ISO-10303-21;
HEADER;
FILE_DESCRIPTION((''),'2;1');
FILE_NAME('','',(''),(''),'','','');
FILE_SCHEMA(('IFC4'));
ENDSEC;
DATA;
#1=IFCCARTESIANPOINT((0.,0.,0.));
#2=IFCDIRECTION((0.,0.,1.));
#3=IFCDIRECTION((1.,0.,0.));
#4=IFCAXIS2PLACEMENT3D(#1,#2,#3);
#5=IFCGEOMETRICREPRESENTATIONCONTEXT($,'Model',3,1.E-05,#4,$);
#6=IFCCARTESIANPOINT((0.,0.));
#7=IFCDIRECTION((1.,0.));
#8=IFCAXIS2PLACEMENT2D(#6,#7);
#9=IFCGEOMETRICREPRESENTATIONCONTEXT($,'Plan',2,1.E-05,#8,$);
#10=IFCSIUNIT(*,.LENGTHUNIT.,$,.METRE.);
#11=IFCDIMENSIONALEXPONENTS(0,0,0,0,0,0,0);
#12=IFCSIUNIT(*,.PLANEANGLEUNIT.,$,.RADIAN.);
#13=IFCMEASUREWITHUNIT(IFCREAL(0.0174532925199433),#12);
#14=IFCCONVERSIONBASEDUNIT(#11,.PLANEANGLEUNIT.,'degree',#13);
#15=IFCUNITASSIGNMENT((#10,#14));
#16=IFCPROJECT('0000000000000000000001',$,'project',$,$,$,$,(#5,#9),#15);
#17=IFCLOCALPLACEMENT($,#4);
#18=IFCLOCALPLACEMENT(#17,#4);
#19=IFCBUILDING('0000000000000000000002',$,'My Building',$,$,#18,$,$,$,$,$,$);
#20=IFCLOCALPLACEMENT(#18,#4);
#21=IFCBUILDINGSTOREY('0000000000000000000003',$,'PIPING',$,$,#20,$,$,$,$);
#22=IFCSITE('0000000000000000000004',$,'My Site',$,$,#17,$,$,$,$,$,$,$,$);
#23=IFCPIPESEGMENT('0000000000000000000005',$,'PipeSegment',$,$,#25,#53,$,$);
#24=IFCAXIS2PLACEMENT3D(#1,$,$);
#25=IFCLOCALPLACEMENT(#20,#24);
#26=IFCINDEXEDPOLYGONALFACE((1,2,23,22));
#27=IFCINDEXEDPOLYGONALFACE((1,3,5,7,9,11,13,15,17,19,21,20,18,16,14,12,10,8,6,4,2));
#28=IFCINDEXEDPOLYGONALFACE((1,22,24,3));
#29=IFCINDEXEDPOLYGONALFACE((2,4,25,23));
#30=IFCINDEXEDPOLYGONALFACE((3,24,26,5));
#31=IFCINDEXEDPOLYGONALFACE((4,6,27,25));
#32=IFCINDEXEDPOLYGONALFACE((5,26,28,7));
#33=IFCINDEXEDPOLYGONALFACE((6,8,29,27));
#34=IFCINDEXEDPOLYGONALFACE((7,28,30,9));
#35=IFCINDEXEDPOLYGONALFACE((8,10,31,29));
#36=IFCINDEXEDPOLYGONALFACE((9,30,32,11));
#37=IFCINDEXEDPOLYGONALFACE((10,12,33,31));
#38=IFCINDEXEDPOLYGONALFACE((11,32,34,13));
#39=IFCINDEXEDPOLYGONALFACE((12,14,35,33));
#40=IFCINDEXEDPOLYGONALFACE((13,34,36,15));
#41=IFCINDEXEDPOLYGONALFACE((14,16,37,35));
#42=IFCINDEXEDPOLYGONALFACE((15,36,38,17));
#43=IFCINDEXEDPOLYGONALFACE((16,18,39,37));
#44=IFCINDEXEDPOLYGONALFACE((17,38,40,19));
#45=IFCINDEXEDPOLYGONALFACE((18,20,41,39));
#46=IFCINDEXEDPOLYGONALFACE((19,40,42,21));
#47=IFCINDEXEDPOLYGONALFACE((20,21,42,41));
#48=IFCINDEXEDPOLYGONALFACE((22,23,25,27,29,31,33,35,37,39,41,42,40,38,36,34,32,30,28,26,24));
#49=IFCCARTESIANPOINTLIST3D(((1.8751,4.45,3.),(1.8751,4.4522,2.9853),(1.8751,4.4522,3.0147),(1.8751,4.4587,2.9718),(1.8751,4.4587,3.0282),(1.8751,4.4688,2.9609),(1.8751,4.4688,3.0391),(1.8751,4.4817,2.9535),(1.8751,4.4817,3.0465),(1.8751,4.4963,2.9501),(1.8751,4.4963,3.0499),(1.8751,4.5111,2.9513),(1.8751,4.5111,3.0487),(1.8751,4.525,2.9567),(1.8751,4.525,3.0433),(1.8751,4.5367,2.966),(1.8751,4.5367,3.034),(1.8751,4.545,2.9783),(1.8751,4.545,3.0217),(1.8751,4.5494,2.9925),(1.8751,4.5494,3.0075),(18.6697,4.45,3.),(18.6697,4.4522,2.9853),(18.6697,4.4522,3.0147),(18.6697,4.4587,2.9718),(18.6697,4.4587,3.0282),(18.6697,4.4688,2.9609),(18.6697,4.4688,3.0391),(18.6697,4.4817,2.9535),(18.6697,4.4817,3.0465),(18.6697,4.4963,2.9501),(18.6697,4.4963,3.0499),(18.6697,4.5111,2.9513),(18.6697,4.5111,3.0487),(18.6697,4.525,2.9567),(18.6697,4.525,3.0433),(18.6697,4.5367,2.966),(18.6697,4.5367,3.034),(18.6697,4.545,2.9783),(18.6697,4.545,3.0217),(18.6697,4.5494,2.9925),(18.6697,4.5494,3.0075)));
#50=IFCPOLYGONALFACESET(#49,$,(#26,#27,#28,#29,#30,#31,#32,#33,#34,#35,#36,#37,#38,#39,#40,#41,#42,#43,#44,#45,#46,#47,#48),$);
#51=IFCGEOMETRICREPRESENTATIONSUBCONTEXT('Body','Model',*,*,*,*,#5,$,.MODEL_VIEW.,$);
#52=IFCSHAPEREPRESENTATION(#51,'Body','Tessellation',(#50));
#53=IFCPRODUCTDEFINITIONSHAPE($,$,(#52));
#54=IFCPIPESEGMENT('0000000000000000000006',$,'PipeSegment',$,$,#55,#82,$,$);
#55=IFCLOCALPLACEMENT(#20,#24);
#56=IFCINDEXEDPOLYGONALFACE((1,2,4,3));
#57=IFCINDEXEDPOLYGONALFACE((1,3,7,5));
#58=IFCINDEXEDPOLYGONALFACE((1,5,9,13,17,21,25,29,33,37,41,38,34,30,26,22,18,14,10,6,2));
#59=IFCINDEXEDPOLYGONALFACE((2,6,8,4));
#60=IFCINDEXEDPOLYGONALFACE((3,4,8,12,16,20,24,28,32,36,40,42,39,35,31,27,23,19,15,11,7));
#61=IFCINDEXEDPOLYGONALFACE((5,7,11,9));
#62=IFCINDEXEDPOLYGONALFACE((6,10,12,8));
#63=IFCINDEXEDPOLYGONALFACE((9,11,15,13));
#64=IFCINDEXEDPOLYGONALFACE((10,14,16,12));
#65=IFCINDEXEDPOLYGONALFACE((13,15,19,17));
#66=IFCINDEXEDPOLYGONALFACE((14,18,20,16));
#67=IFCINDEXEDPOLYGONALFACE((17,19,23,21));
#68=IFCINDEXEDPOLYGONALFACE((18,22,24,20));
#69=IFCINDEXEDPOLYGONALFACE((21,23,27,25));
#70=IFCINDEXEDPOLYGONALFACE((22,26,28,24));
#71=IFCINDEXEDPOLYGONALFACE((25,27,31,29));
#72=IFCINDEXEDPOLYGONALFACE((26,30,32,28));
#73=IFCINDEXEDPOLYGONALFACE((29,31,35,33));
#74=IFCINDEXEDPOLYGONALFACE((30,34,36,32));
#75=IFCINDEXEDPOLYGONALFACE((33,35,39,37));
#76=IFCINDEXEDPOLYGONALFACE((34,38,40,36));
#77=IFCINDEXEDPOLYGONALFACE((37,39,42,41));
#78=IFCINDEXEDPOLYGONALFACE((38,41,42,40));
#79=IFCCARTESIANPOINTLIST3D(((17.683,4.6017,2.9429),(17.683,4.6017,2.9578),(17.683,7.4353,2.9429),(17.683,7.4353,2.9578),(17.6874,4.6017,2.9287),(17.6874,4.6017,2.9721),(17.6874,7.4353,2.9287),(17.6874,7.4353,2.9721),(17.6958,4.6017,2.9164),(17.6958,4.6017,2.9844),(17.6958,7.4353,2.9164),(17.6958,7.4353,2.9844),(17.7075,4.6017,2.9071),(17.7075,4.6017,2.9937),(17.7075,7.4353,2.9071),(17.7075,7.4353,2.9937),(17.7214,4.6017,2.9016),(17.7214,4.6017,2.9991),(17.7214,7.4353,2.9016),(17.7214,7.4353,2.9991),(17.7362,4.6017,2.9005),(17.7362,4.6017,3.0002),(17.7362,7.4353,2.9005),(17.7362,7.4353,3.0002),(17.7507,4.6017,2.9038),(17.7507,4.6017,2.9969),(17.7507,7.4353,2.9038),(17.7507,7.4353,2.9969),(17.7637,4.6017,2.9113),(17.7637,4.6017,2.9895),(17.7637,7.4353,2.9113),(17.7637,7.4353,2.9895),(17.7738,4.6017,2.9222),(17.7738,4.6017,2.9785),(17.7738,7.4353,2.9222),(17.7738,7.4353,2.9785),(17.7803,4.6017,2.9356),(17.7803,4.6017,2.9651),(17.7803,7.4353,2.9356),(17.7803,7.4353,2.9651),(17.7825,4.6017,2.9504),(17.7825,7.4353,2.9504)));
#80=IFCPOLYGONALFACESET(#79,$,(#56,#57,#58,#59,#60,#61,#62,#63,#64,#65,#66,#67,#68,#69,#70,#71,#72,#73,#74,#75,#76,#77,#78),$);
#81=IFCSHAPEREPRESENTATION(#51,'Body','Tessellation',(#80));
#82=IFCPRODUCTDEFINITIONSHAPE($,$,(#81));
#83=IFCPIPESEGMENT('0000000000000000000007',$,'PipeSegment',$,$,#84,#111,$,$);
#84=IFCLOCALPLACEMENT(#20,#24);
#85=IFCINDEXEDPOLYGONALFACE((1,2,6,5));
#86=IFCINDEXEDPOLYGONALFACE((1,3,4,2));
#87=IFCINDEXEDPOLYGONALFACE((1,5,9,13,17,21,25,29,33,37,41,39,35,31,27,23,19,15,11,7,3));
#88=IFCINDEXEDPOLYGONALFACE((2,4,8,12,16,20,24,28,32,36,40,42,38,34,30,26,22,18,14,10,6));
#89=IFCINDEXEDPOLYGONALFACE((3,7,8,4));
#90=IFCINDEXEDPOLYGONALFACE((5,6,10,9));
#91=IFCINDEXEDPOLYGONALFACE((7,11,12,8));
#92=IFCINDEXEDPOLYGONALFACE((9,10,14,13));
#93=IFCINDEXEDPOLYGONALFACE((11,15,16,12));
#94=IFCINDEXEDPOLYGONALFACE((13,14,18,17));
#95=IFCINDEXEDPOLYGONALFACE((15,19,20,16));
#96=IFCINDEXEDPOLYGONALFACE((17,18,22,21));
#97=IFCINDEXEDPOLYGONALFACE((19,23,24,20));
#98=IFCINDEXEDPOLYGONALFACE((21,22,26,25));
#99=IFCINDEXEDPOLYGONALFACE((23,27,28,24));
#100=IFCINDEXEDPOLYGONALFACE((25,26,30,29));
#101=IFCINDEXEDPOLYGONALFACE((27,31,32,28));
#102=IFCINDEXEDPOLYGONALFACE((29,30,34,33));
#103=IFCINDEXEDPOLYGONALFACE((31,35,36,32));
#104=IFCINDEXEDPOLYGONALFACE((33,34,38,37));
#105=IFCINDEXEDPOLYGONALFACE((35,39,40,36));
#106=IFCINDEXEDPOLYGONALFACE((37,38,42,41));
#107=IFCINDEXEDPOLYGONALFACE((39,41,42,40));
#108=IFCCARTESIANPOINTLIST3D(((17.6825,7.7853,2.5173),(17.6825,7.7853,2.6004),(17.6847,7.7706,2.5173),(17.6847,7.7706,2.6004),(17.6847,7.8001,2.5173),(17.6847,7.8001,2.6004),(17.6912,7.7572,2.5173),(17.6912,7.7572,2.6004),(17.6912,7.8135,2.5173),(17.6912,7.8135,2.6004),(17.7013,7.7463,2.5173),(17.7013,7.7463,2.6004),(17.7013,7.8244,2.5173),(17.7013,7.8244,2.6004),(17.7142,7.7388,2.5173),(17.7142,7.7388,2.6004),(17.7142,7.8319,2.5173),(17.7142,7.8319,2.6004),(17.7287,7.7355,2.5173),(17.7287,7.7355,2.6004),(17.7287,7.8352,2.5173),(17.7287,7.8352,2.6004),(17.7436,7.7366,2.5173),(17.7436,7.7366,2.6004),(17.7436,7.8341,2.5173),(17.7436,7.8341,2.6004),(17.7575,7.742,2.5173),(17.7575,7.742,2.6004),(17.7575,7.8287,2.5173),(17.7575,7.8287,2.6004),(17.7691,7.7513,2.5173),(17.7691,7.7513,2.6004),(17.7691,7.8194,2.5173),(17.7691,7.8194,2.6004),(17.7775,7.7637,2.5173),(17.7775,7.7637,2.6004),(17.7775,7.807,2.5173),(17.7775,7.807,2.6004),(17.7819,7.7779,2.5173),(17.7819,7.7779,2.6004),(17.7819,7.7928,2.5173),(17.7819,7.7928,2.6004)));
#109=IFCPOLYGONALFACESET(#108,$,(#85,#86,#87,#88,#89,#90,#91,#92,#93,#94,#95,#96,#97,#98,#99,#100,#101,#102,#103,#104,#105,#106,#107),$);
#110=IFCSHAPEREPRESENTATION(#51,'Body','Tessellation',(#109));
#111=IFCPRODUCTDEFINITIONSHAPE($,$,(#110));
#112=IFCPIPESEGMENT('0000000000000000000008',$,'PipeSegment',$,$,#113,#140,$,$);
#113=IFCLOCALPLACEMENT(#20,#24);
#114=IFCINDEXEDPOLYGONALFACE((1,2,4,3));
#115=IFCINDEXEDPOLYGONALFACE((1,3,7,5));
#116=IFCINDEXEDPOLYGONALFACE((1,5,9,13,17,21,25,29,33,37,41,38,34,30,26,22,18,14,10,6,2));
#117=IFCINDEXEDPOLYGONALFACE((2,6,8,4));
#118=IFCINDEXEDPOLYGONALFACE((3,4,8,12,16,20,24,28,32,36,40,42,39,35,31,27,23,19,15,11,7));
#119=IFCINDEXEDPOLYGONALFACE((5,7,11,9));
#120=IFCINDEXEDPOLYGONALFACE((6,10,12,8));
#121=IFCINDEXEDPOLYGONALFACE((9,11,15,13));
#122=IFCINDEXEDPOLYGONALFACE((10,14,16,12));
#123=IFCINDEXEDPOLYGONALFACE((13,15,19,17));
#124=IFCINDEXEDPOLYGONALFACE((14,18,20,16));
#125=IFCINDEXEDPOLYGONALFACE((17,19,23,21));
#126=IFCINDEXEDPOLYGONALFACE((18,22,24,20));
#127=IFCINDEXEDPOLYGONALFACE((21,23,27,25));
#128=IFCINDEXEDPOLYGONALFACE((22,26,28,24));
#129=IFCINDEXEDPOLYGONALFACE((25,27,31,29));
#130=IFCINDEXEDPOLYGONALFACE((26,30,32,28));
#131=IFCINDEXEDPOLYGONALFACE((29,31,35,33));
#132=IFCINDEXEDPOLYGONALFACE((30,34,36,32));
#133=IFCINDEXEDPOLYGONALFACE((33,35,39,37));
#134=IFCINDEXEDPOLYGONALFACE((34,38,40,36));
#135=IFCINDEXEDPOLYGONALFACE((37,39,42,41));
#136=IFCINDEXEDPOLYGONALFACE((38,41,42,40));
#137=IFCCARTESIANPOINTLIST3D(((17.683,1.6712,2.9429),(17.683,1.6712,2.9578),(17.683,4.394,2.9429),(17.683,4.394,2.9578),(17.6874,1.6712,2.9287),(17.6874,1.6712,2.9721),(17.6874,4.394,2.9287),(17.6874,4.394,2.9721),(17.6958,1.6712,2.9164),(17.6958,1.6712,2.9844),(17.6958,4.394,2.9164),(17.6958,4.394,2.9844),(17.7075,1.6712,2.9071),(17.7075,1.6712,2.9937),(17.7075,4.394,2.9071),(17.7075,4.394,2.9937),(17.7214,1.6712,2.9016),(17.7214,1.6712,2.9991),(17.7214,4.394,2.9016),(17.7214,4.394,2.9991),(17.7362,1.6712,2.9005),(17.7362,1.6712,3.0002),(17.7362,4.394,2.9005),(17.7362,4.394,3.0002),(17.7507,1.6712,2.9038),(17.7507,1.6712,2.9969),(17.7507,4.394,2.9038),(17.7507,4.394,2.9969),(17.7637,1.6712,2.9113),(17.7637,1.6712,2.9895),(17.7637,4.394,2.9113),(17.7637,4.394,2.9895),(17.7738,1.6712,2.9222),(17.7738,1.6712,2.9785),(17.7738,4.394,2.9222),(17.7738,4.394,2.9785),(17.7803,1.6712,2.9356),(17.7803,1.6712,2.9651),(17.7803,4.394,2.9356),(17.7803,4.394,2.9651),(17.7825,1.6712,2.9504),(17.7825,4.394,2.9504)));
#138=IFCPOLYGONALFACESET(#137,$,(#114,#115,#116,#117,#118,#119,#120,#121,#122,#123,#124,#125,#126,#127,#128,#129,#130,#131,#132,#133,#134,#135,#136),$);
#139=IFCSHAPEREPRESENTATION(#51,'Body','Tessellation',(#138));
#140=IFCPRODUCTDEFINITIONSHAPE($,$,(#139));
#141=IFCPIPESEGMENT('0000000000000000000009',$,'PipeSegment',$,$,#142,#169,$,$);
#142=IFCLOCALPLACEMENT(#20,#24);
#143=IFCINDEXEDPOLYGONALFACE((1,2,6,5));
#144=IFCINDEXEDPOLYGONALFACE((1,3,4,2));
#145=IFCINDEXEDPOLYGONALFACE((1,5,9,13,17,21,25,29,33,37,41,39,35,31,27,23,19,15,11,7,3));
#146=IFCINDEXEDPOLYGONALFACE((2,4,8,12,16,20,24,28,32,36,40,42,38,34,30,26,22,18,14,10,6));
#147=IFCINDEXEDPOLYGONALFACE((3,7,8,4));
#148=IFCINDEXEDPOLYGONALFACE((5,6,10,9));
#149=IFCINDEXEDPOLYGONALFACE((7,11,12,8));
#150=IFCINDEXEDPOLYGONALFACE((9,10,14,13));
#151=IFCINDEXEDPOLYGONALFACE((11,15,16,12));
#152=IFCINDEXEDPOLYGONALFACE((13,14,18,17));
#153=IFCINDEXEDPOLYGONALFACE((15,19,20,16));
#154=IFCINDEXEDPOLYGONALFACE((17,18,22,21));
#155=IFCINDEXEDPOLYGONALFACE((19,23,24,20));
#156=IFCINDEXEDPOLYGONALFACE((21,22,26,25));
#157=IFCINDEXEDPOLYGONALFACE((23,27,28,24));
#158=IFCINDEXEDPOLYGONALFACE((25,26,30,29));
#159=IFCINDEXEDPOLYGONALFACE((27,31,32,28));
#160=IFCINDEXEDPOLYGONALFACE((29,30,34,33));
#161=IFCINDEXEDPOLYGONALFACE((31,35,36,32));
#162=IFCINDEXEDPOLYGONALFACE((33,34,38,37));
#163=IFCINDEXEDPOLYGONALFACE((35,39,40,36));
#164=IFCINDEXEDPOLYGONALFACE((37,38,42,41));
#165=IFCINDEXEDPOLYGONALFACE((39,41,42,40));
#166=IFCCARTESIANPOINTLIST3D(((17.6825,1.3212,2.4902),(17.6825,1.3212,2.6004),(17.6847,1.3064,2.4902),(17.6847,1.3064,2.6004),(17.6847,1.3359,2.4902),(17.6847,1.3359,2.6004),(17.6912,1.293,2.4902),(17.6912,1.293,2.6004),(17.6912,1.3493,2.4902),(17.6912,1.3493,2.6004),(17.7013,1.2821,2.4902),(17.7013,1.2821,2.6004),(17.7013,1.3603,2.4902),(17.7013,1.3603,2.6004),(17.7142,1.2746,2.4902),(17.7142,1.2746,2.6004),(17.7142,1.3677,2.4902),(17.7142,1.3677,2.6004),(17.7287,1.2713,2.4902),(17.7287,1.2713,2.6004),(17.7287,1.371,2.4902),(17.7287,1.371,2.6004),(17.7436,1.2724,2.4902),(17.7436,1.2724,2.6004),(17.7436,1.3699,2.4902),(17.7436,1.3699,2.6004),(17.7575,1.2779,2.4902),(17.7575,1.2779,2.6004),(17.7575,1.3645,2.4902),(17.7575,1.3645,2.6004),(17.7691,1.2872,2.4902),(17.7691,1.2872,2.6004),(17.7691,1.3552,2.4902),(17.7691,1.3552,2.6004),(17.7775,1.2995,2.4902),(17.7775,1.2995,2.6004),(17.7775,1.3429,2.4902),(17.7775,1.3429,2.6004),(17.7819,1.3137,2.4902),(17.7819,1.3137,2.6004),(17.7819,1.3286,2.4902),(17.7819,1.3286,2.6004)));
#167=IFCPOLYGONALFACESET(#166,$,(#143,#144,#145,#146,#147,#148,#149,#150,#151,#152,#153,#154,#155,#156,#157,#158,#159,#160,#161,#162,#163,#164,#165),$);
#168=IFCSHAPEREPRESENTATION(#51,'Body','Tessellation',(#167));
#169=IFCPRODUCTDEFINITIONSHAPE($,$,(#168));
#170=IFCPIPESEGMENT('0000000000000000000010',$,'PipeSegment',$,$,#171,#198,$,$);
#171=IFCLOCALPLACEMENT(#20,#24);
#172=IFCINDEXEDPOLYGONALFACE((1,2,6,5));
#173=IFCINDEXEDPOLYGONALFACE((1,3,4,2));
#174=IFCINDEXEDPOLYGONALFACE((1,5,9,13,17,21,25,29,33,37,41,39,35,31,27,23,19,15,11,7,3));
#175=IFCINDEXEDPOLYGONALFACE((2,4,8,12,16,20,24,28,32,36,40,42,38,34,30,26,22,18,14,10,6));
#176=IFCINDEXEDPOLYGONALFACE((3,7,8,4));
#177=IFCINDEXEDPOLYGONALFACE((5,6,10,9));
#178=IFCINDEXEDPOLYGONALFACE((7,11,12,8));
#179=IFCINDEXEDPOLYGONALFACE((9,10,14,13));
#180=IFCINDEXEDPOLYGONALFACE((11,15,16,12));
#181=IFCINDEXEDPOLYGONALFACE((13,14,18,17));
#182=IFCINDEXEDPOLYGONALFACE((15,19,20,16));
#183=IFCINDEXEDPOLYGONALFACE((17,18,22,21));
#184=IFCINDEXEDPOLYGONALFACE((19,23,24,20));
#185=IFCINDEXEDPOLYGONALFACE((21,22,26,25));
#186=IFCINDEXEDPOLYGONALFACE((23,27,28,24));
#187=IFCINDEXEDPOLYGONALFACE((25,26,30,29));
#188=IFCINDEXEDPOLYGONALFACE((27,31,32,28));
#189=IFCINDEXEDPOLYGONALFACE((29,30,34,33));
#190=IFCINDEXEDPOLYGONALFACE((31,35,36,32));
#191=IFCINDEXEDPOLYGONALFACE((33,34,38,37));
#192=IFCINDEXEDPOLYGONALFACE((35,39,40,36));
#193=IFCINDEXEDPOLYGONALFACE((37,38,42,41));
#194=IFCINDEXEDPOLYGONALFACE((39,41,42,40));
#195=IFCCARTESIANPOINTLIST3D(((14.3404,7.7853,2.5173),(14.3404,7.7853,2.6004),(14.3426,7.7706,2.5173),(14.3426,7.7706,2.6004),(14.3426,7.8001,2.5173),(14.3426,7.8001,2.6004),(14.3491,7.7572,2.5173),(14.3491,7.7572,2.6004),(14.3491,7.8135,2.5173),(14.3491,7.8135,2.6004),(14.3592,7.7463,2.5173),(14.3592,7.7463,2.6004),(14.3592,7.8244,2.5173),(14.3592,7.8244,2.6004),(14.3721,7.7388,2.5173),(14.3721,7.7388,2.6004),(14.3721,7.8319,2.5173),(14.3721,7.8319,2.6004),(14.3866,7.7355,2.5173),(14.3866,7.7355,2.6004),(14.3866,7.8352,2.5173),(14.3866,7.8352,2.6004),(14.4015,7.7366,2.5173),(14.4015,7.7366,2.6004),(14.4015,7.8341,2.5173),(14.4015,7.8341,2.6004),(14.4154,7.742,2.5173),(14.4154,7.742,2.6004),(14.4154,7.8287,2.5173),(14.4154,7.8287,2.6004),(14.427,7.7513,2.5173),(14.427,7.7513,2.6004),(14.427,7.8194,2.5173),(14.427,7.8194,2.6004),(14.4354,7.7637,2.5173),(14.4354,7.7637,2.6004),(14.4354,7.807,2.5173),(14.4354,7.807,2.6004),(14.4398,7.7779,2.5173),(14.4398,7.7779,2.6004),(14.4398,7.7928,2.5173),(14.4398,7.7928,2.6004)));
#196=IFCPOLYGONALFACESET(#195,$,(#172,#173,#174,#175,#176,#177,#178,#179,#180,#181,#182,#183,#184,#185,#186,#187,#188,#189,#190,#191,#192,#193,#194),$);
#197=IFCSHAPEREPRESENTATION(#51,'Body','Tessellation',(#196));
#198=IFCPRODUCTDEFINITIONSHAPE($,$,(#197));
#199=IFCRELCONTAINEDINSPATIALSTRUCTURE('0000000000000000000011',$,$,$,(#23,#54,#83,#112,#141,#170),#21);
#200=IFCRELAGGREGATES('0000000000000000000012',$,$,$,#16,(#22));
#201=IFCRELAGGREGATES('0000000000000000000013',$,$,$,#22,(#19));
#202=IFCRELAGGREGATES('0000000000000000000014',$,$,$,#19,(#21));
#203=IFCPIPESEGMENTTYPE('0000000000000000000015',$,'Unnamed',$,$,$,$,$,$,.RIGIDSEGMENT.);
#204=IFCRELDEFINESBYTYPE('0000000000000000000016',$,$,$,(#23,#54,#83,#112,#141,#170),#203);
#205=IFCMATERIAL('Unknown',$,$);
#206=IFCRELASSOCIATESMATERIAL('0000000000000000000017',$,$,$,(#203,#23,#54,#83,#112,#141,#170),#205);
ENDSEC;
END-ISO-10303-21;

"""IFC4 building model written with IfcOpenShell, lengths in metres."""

from ifc_helpers import new_model, entity, si_unit, converted_unit, frame, origin_with_axes, origin_2d_with_axis, place, context, subcontext, project, spatial, circle, extrude, material, material_profile, profile_set, profile_usage, type_object, element, save


model = new_model("IFC4")

# Units and contexts
model_context = context("Model", 3, precision=1e-05, world=origin_with_axes())
plan_context = context("Plan", 2, precision=1e-05, world=origin_2d_with_axis())
body_context = subcontext(model_context, "Body", "Model", "MODEL_VIEW")
ifc_project = project(units=[si_unit("LENGTHUNIT", "METRE"), converted_unit("PLANEANGLEUNIT", "degree", entity("IfcReal", 0.0174532925199433), si_unit("PLANEANGLEUNIT", "RADIAN"), dimensions=[0, 0, 0, 0, 0, 0, 0])], contexts=[model_context, plan_context])

# Site, building, storey
site_placement = place(None, origin_with_axes())
site = spatial("IfcSite", under=ifc_project, at=site_placement, Name="My Site")
building_placement = place(site_placement, origin_with_axes())
building = spatial("IfcBuilding", under=site, at=building_placement, Name="My Building")
storey_placement = place(building_placement, origin_with_axes())
storey = spatial("IfcBuildingStorey", under=building, at=storey_placement, Name="PIPING")

# Pipe segments
ifc_material = material(Name="Unknown")
ifc_material_profile_1 = material_profile(ifc_material, circle(Radius=0.05))
ifc_profile_set_1 = profile_set([ifc_material_profile_1])
ifc_profile_usage_1 = profile_usage(ifc_profile_set_1, cardinal=5)
pipe_segment_type = type_object("IfcPipeSegmentType", Name="Unnamed", PredefinedType="RIGIDSEGMENT", material=ifc_profile_set_1)
pipe_segment_1_placement = place(storey_placement, frame((18.6697, 4.5, 3.0), z_axis=(-1.0, 0.0, 0.0), x_axis=(0.0, -1.0, 0.0)))
element("IfcPipeSegment", 1, at=pipe_segment_1_placement, inside=storey, type_object=pipe_segment_type, material=ifc_profile_usage_1, Name="PipeSegment", context=body_context, shape_type="SweptSolid", body=[
    extrude(circle(Radius=0.05), origin_with_axes(), (0.0, 0.0, 1.0), 16.7946),
])
ifc_profile_usage_2 = profile_usage(ifc_profile_set_1, cardinal=5)
pipe_segment_2_placement = place(storey_placement, frame((17.7325, 4.6017, 2.9504), z_axis=(0.0, 1.0, 0.0), x_axis=(1.0, 0.0, 0.0)))
element("IfcPipeSegment", 2, at=pipe_segment_2_placement, inside=storey, type_object=pipe_segment_type, material=ifc_profile_usage_2, Name="PipeSegment", context=body_context, shape_type="SweptSolid", body=[
    extrude(circle(Radius=0.05), origin_with_axes(), (0.0, 0.0, 1.0), 2.8337),
])
ifc_profile_usage_3 = profile_usage(ifc_profile_set_1, cardinal=5)
pipe_segment_3_placement = place(storey_placement, frame((17.7325, 7.7853, 2.6004), z_axis=(0.0, 0.0, -1.0), x_axis=(-1.0, 0.0, 0.0)))
element("IfcPipeSegment", 3, at=pipe_segment_3_placement, inside=storey, type_object=pipe_segment_type, material=ifc_profile_usage_3, Name="PipeSegment", context=body_context, shape_type="SweptSolid", body=[
    extrude(circle(Radius=0.05), origin_with_axes(), (0.0, 0.0, 1.0), 0.0831),
])
ifc_profile_usage_4 = profile_usage(ifc_profile_set_1, cardinal=5)
pipe_segment_4_placement = place(storey_placement, frame((17.7325, 1.6712, 2.9504), z_axis=(0.0, 1.0, 0.0), x_axis=(1.0, 0.0, 0.0)))
element("IfcPipeSegment", 4, at=pipe_segment_4_placement, inside=storey, type_object=pipe_segment_type, material=ifc_profile_usage_4, Name="PipeSegment", context=body_context, shape_type="SweptSolid", body=[
    extrude(circle(Radius=0.05), origin_with_axes(), (0.0, 0.0, 1.0), 2.7228),
])
ifc_profile_usage_5 = profile_usage(ifc_profile_set_1, cardinal=5)
pipe_segment_5_placement = place(storey_placement, frame((17.7325, 1.3212, 2.6004), z_axis=(0.0, 0.0, -1.0), x_axis=(-1.0, 0.0, 0.0)))
element("IfcPipeSegment", 5, at=pipe_segment_5_placement, inside=storey, type_object=pipe_segment_type, material=ifc_profile_usage_5, Name="PipeSegment", context=body_context, shape_type="SweptSolid", body=[
    extrude(circle(Radius=0.05), origin_with_axes(), (0.0, 0.0, 1.0), 0.1102),
])
ifc_profile_usage_6 = profile_usage(ifc_profile_set_1, cardinal=5)
pipe_segment_6_placement = place(storey_placement, frame((14.3904, 7.7853, 2.6004), z_axis=(0.0, 0.0, -1.0), x_axis=(-1.0, 0.0, 0.0)))
element("IfcPipeSegment", 6, at=pipe_segment_6_placement, inside=storey, type_object=pipe_segment_type, material=ifc_profile_usage_6, Name="PipeSegment", context=body_context, shape_type="SweptSolid", body=[
    extrude(circle(Radius=0.05), origin_with_axes(), (0.0, 0.0, 1.0), 0.0831),
])

save(model, "model.ifc")
